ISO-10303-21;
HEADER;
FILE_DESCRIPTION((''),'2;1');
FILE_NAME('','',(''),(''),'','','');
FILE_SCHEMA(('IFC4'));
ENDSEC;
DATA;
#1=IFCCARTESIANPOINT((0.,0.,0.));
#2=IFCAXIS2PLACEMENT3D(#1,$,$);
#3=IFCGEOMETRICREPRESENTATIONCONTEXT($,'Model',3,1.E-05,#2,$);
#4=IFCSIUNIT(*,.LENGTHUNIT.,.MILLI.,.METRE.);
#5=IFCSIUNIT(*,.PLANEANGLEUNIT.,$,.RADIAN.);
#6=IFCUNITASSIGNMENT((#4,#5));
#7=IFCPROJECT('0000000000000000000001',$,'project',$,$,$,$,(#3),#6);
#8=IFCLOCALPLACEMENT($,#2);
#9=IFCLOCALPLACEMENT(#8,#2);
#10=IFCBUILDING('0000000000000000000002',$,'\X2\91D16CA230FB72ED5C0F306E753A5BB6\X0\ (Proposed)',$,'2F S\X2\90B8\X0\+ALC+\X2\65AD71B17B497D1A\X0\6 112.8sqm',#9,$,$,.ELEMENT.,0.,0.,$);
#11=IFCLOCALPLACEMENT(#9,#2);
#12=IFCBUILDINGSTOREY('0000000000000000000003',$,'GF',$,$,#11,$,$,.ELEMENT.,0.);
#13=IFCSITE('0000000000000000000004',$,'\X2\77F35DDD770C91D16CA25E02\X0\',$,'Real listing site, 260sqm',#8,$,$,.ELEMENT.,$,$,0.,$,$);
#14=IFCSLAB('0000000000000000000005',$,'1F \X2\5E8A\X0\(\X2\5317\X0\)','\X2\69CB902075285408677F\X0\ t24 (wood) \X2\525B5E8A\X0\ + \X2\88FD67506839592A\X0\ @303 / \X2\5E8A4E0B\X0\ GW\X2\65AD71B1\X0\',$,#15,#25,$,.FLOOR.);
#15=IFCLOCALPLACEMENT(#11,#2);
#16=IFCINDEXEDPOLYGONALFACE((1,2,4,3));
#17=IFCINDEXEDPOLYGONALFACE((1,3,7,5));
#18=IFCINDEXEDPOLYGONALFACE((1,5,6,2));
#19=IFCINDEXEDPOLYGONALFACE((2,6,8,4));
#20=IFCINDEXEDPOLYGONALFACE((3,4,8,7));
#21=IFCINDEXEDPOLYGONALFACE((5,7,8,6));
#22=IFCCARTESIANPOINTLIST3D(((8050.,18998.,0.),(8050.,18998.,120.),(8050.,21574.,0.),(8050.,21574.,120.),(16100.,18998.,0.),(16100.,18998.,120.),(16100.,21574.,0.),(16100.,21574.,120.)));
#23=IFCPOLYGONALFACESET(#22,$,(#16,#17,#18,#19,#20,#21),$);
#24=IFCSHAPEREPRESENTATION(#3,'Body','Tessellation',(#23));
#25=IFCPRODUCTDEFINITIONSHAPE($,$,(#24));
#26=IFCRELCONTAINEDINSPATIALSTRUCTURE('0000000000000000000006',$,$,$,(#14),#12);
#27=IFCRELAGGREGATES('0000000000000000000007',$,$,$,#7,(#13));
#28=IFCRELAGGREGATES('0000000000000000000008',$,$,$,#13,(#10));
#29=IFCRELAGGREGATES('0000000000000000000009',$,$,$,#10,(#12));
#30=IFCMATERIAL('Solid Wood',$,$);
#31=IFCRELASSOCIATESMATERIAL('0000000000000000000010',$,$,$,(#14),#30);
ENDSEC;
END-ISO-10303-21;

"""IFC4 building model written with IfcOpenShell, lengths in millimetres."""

from ifc_helpers import new_model, si_unit, frame, frame_2d, origin, place, context, project, spatial, rectangle, extrude, material, element, save


model = new_model("IFC4")

# Units and contexts
model_context = context("Model", 3, precision=1e-05, world=origin())
ifc_project = project(units=[si_unit("LENGTHUNIT", "METRE", prefix="MILLI"), si_unit("PLANEANGLEUNIT", "RADIAN")], contexts=[model_context])

# Site, building, storey
site_placement = place(None, origin())
site = spatial("IfcSite", under=ifc_project, at=site_placement, Name="石川県金沢市", ObjectType="Real listing site, 260sqm", CompositionType="ELEMENT", RefElevation=0.0)
building_placement = place(site_placement, origin())
building = spatial("IfcBuilding", under=site, at=building_placement, Name="金沢・狭小の町家 (Proposed)", ObjectType="2F S邸+ALC+断熱等級6 112.8sqm", CompositionType="ELEMENT", ElevationOfRefHeight=0.0, ElevationOfTerrain=0.0)
storey_placement = place(building_placement, origin())
storey = spatial("IfcBuildingStorey", under=building, at=storey_placement, Name="GF", CompositionType="ELEMENT", Elevation=0.0)

# Shared definitions
ifc_material_1 = material(Name="Solid Wood")

# Slab
slab_placement = place(storey_placement, frame((4025.0, 9499.0, 0.0)))
element("IfcSlab", 1, at=slab_placement, inside=storey, material=ifc_material_1, Name="1F 床(北)", Description="構造用合板 t24 (wood) 剛床 + 製材根太 @303 / 床下 GW断熱", PredefinedType="FLOOR", context=model_context, shape_type="SweptSolid", body=[
    extrude(rectangle(XDim=8050.0, YDim=2576.0, at=frame_2d((4025.0, 1288.0))), frame((4025.0, 9499.0, 0.0)), (0.0, 0.0, 1.0), 120.0),
])

save(model, "model.ifc")
